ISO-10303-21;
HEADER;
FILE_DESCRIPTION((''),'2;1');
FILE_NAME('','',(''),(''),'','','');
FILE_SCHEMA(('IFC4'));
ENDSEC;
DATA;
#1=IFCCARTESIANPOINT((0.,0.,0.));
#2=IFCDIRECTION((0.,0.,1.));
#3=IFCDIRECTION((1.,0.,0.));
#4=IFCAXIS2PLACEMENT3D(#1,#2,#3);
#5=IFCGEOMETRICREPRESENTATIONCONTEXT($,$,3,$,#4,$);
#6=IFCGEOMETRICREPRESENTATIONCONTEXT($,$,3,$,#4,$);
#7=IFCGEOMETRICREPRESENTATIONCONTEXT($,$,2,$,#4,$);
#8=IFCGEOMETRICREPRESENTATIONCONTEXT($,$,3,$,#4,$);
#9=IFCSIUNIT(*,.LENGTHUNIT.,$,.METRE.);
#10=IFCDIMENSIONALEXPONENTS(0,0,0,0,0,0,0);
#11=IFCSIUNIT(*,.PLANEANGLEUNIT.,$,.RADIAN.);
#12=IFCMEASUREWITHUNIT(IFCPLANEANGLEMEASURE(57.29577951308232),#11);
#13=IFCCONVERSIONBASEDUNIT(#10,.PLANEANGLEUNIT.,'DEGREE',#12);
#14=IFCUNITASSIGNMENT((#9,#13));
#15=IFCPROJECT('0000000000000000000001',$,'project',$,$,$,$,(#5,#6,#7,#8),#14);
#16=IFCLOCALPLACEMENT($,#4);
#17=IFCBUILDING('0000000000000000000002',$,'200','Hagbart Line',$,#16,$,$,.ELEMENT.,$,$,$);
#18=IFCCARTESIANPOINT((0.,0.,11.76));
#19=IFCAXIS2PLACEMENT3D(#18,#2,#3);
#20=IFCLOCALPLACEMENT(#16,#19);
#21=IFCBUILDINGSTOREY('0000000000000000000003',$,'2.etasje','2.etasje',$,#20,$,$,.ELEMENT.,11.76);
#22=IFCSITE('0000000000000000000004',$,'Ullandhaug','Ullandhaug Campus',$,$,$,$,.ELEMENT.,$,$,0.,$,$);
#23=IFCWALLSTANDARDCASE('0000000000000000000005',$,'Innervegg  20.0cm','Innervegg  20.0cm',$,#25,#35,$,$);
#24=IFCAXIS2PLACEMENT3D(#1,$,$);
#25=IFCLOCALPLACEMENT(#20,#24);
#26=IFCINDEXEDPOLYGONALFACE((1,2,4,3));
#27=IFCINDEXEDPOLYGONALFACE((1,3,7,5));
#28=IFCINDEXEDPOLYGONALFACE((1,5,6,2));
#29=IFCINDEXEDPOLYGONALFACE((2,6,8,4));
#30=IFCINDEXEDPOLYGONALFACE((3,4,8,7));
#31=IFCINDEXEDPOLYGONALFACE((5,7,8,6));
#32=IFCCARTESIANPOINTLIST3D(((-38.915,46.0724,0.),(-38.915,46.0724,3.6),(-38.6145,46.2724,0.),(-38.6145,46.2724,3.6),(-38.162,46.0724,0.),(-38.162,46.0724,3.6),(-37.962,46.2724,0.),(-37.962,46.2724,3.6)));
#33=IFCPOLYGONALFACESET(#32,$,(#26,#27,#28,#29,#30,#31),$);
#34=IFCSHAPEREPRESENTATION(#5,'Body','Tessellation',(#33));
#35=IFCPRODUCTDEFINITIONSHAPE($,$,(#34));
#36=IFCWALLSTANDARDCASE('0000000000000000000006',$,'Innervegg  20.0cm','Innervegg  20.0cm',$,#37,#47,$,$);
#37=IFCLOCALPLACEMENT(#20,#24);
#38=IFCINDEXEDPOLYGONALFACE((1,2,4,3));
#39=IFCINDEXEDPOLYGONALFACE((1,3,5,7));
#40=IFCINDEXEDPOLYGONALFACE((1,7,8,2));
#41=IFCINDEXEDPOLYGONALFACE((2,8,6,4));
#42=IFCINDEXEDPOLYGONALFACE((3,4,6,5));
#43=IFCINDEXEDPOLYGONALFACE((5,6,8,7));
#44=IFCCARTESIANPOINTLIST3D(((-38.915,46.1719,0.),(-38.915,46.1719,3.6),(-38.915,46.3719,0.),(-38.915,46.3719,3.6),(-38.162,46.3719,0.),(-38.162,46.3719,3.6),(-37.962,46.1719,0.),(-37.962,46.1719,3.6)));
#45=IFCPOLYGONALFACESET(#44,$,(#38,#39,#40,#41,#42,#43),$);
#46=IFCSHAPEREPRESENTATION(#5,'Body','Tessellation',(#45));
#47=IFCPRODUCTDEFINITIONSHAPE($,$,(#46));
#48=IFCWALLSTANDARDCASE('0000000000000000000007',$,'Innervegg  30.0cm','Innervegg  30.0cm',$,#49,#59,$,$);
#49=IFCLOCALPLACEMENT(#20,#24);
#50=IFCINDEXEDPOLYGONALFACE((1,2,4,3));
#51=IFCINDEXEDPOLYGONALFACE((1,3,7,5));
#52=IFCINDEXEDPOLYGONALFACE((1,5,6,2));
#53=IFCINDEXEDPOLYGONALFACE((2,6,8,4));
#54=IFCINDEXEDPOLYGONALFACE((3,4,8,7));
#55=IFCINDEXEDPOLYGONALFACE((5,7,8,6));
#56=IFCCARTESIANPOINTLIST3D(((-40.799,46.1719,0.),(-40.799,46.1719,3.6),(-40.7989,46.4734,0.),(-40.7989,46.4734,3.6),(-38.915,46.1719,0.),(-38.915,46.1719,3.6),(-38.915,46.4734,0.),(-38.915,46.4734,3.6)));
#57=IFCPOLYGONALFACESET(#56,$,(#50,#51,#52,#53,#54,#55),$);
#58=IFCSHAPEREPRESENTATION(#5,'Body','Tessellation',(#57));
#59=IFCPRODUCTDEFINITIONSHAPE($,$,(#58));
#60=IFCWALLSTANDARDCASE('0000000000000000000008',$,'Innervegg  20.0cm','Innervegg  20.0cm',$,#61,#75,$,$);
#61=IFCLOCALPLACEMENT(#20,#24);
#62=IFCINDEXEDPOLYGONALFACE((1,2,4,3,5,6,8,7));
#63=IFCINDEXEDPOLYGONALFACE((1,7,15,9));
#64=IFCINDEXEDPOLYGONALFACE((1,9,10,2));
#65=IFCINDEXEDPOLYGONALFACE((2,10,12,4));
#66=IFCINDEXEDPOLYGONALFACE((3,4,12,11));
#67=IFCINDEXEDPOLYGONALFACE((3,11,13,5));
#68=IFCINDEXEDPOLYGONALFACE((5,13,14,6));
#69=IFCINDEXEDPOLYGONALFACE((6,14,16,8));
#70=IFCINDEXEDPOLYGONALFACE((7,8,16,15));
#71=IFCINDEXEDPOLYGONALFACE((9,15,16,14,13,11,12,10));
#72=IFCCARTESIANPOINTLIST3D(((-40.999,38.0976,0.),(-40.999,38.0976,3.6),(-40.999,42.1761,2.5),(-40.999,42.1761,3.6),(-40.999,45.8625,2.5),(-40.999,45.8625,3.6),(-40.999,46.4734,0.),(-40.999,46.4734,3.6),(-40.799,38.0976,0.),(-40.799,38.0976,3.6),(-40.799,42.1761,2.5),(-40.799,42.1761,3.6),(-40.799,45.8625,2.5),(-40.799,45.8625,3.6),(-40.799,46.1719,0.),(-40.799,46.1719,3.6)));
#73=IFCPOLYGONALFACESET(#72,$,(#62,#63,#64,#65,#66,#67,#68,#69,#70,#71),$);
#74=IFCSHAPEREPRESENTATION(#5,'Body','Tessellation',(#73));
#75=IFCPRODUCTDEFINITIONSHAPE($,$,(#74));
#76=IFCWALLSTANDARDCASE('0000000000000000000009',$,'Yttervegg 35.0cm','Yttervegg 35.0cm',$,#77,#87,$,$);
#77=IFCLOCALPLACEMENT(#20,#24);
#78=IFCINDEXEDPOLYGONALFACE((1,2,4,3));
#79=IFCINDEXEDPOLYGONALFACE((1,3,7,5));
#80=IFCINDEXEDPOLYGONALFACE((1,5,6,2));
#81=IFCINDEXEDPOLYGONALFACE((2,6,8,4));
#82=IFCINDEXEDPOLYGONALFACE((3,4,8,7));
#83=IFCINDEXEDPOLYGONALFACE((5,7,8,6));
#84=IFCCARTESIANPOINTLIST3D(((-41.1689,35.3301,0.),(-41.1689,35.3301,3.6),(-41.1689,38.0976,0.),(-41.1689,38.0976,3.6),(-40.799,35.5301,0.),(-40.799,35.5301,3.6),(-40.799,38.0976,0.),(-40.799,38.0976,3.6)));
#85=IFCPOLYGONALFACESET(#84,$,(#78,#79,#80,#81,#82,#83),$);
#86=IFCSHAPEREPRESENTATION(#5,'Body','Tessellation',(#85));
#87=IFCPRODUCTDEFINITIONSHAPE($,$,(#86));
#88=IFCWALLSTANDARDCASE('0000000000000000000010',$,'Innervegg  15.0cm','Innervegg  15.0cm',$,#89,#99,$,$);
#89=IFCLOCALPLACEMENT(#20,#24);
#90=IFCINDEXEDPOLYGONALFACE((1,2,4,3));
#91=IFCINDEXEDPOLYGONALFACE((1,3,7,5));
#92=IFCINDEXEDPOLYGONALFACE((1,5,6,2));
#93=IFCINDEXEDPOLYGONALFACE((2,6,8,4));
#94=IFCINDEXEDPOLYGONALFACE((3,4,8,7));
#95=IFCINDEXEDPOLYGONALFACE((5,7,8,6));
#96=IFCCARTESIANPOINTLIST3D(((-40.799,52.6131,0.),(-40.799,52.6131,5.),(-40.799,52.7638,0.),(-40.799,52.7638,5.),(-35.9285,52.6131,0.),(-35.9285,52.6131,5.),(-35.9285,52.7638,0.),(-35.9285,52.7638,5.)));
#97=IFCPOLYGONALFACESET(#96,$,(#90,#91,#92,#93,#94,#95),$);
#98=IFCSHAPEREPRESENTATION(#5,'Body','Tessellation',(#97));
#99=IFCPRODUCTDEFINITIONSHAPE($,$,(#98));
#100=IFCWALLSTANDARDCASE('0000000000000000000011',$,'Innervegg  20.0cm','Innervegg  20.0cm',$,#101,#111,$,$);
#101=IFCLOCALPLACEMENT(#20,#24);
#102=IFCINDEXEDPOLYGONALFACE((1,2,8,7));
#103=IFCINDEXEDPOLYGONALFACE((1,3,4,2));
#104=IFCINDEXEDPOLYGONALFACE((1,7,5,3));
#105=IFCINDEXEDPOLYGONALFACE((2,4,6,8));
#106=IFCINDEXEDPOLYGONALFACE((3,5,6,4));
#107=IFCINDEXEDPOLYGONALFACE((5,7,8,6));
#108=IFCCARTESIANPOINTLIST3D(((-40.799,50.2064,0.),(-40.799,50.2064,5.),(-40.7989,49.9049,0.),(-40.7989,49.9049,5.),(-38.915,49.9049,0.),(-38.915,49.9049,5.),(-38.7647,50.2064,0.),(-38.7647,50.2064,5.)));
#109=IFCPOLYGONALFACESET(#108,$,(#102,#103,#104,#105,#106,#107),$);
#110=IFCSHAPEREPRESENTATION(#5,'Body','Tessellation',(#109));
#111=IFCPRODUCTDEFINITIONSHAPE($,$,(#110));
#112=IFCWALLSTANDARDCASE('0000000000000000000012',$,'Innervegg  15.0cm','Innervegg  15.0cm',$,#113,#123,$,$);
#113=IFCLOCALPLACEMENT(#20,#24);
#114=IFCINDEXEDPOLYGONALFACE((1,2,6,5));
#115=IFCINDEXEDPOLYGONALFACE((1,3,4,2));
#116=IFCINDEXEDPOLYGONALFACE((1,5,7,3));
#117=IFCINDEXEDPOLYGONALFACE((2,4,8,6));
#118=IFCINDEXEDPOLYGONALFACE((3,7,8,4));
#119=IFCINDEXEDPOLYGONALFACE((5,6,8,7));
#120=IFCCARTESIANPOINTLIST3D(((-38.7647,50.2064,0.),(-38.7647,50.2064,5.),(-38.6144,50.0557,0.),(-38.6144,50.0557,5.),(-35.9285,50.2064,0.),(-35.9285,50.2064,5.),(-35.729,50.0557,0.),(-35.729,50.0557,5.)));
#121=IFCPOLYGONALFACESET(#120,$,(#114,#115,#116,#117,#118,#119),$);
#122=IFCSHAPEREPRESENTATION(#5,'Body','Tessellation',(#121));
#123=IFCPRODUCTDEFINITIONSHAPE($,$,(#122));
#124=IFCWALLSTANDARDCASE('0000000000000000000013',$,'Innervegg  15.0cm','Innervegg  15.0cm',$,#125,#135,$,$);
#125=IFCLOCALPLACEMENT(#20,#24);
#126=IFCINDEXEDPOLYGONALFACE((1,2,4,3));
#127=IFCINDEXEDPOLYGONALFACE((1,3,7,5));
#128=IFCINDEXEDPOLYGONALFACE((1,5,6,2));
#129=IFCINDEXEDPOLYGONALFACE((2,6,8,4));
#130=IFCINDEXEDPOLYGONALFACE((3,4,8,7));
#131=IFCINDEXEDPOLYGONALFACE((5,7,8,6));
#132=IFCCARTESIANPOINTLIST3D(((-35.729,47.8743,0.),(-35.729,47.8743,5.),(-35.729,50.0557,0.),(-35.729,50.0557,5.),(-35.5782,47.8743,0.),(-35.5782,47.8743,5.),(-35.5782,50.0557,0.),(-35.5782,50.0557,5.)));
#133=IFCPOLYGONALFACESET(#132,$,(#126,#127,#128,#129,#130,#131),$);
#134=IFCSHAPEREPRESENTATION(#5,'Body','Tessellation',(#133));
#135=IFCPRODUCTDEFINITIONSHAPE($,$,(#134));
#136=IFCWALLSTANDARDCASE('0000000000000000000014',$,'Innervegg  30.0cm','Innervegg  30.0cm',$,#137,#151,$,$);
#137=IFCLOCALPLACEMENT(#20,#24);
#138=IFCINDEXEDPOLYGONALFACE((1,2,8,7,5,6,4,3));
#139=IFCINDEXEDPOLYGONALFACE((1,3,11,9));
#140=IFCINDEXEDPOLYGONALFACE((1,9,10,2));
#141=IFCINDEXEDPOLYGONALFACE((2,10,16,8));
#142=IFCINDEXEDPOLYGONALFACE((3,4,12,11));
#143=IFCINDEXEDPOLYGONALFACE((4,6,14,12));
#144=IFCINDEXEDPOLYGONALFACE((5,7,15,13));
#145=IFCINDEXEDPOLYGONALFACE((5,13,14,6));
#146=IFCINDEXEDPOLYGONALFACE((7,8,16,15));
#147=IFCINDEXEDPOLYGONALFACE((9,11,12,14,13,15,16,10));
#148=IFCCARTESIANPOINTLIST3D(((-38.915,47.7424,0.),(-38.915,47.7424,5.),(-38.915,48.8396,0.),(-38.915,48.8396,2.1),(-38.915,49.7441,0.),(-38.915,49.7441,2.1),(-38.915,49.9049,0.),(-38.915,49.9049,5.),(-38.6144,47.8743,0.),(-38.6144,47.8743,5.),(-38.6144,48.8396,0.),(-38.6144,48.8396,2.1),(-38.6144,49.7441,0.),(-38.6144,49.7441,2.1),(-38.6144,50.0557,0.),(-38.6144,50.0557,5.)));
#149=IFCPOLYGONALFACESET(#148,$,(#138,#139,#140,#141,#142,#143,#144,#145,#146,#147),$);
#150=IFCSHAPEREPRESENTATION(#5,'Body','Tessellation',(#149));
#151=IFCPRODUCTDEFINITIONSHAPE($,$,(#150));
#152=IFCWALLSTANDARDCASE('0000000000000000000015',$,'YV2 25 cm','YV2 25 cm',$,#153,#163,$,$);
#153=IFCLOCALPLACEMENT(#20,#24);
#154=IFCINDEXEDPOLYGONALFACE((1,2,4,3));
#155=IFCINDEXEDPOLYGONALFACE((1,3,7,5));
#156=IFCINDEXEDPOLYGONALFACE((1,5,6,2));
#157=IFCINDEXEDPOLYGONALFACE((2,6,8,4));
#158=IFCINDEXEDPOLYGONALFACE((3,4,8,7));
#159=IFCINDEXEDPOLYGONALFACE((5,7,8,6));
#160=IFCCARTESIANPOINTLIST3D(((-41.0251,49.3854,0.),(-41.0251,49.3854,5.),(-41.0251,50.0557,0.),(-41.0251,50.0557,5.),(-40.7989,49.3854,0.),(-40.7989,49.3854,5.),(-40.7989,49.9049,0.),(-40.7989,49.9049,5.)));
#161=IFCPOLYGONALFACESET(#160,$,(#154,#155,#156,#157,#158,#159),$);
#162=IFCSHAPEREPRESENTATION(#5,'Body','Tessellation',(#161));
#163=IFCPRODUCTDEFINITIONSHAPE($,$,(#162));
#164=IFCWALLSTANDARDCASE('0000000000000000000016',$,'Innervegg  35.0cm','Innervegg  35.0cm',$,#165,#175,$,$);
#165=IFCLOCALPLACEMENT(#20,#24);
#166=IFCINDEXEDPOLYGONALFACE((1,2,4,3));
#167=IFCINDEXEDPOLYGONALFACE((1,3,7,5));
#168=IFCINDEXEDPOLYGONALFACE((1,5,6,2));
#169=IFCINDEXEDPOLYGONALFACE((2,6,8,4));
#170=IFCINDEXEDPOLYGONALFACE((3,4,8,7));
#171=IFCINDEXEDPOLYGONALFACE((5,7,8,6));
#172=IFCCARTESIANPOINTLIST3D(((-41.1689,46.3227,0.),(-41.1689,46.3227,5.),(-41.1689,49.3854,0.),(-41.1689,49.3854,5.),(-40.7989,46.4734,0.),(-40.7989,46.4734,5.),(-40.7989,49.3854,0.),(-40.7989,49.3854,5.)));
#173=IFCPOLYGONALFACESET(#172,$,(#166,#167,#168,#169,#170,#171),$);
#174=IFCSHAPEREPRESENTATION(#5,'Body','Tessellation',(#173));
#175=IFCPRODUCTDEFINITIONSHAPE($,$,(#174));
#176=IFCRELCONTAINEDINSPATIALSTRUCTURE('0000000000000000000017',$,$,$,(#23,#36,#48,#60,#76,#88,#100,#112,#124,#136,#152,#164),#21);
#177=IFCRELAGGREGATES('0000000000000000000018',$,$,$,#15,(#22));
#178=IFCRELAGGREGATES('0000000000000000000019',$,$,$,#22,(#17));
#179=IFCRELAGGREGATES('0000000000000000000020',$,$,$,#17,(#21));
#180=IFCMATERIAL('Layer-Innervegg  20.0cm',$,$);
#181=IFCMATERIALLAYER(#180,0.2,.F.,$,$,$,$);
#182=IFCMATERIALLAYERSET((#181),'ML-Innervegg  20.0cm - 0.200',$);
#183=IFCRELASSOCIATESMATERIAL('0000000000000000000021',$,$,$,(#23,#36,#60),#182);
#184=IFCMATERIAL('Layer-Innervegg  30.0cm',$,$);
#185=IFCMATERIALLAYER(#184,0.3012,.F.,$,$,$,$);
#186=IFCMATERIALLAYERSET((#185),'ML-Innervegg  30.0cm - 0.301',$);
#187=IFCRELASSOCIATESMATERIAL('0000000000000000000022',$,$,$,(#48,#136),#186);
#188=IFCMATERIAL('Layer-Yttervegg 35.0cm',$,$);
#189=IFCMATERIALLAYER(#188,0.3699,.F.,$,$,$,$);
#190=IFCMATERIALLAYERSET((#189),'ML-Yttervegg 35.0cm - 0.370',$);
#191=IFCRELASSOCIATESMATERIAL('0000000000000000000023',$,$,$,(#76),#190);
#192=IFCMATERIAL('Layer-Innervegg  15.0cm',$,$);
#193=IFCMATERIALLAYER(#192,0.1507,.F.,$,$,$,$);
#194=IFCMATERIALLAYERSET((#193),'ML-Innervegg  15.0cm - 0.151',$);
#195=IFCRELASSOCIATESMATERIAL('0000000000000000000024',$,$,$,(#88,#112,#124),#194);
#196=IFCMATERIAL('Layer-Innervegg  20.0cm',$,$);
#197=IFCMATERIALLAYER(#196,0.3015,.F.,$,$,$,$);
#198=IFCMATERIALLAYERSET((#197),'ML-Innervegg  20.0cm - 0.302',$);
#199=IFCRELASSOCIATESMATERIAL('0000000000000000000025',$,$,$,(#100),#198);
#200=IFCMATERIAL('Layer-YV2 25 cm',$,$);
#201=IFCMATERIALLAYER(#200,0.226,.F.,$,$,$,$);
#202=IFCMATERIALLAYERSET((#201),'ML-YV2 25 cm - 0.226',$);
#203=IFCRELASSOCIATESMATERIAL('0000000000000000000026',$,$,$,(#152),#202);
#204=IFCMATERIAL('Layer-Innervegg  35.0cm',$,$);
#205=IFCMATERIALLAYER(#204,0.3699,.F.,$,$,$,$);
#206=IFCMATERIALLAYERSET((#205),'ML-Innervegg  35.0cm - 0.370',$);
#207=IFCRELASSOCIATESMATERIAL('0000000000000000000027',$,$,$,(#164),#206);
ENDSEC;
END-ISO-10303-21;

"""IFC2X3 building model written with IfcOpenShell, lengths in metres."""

from ifc_helpers import new_model, entity, si_unit, converted_unit, frame, origin_with_axes, place, context, project, spatial, polyline, outline, extrude, material, layer, layer_set, layer_usage, element, save


model = new_model("IFC2X3")

# Units and contexts
context_of_model_1 = context(None, 3, world=origin_with_axes())
context_of_model_2 = context(None, 3, world=origin_with_axes())
context_of_model_3 = context(None, 2, world=origin_with_axes())
context_of_model_4 = context(None, 3, world=origin_with_axes())
ifc_project = project(units=[si_unit("LENGTHUNIT", "METRE"), converted_unit("PLANEANGLEUNIT", "DEGREE", entity("IfcPlaneAngleMeasure", 57.29577951308232), si_unit("PLANEANGLEUNIT", "RADIAN"), dimensions=[0, 0, 0, 0, 0, 0, 0])], contexts=[context_of_model_1, context_of_model_2, context_of_model_3, context_of_model_4])

# Site, building, storey
site = spatial("IfcSite", under=ifc_project, Name="Ullandhaug", Description="Ullandhaug Campus", CompositionType="ELEMENT", RefElevation=0.0)
building_placement = place(None, origin_with_axes())
building = spatial("IfcBuilding", under=site, at=building_placement, Name="200", Description="Hagbart Line", CompositionType="ELEMENT")
storey_placement = place(building_placement, frame((0.0, 0.0, 11.76), z_axis=(0.0, 0.0, 1.0), x_axis=(1.0, 0.0, 0.0)))
storey = spatial("IfcBuildingStorey", under=building, at=storey_placement, Name="2.etasje", Description="2.etasje", CompositionType="ELEMENT", Elevation=11.76)

# Walls
ifc_material_1 = material(Name="Layer-Innervegg  35.0cm")
ifc_layer_1 = layer(ifc_material_1, 0.3699, ventilated=False)
ifc_layer_set_1 = layer_set([ifc_layer_1], Name="ML-Innervegg  35.0cm - 0.370")
ifc_layer_usage_1 = layer_usage(ifc_layer_set_1, "AXIS2", "POSITIVE", 0.0)
ifc_material_2 = material(Name="Layer-Innervegg  20.0cm")
ifc_layer_2 = layer(ifc_material_2, 0.2, ventilated=False)
ifc_layer_set_2 = layer_set([ifc_layer_2], Name="ML-Innervegg  20.0cm - 0.200")
ifc_layer_usage_2 = layer_usage(ifc_layer_set_2, "AXIS2", "POSITIVE", 0.0)
wall_1_placement = place(storey_placement, frame((-38.915, 46.0724, 0.0), z_axis=(0.0, 0.0, 1.0), x_axis=(1.0, 0.0, 0.0)))
element("IfcWallStandardCase", 1, at=wall_1_placement, inside=storey, material=ifc_layer_usage_2, Name="Innervegg  20.0cm", Description="Innervegg  20.0cm", context=context_of_model_1, shape_type="SweptSolid", body=[
    extrude(outline(polyline([(0.0, 0.0), (0.753, 0.0), (0.953, 0.2), (0.3005, 0.2), (0.0, 0.0)])), origin_with_axes(), (0.0, 0.0, 1.0), 3.6),
])
wall_2_placement = place(storey_placement, frame((-38.162, 46.3719, 0.0), z_axis=(0.0, 0.0, 1.0), x_axis=(-1.0, 0.0, 0.0)))
element("IfcWallStandardCase", 2, at=wall_2_placement, inside=storey, material=ifc_layer_usage_2, Name="Innervegg  20.0cm", Description="Innervegg  20.0cm", context=context_of_model_1, shape_type="SweptSolid", body=[
    extrude(outline(polyline([(0.0, 0.0), (0.753, 0.0), (0.753, 0.2), (-0.2, 0.2), (0.0, 0.0)])), frame((0.0, 0.0, 0.0), z_axis=(0.0, 0.0, 1.0), x_axis=(1.0, 0.0, 0.0)), (0.0, 0.0, 1.0), 3.6),
])
ifc_material_3 = material(Name="Layer-Innervegg  30.0cm")
ifc_layer_3 = layer(ifc_material_3, 0.3012, ventilated=False)
ifc_layer_set_3 = layer_set([ifc_layer_3], Name="ML-Innervegg  30.0cm - 0.301")
ifc_layer_usage_3 = layer_usage(ifc_layer_set_3, "AXIS2", "POSITIVE", 0.0)
wall_3_placement = place(storey_placement, frame((-38.915, 46.4734, 0.0), z_axis=(0.0, 0.0, 1.0), x_axis=(-1.0, 0.0, 0.0)))
element("IfcWallStandardCase", 3, at=wall_3_placement, inside=storey, material=ifc_layer_usage_3, Name="Innervegg  30.0cm", Description="Innervegg  30.0cm", context=context_of_model_1, shape_type="SweptSolid", body=[
    extrude(outline(polyline([(0.0, 0.0), (1.8839, 0.0), (1.884, 0.3015), (0.0, 0.3015), (0.0, 0.0)])), frame((0.0, 0.0, 0.0), z_axis=(0.0, 0.0, 1.0), x_axis=(1.0, 0.0, 0.0)), (0.0, 0.0, 1.0), 3.6),
])

# Wall, opening
wall_4_placement = place(storey_placement, frame((-40.999, 46.4734, 0.0), z_axis=(0.0, 0.0, 1.0), x_axis=(0.0, -1.0, 0.0)))
wall_4 = element("IfcWallStandardCase", 4, at=wall_4_placement, inside=storey, material=ifc_layer_usage_2, Name="Innervegg  20.0cm", Description="Innervegg  20.0cm", context=context_of_model_1, shape_type="SweptSolid", body=[
    extrude(outline(polyline([(0.0, 0.0), (8.3758, 0.0), (8.3758, 0.2), (0.3015, 0.2), (0.0, 0.0)])), frame((0.0, 0.0, 0.0), z_axis=(0.0, 0.0, 1.0), x_axis=(1.0, 0.0, 0.0)), (0.0, 0.0, 1.0), 3.6),
])
opening_1_placement = place(wall_4_placement, frame((0.611, 0.2, 2.5), z_axis=(0.0, 0.0, 1.0), x_axis=(1.0, 0.0, 0.0)))
element("IfcOpeningElement", 5, at=opening_1_placement, cuts=wall_4, context=context_of_model_1, shape_type="SweptSolid", body=[
    extrude(outline(polyline([(0.0, 0.0), (2.0, 0.0), (2.0, 3.6863), (0.0, 3.6863), (0.0, 0.0)])), frame((0.0, 0.0, 0.0), z_axis=(0.0, 1.0, 0.0), x_axis=(0.0, 0.0, 1.0)), (0.0, 0.0, -1.0), 0.2),
])

# Walls
ifc_material_4 = material(Name="Layer-Yttervegg 35.0cm")
ifc_layer_4 = layer(ifc_material_4, 0.3699, ventilated=False)
ifc_layer_set_4 = layer_set([ifc_layer_4], Name="ML-Yttervegg 35.0cm - 0.370")
ifc_layer_usage_4 = layer_usage(ifc_layer_set_4, "AXIS2", "POSITIVE", 0.0)
wall_5_placement = place(storey_placement, frame((-41.1689, 38.0976, 0.0), z_axis=(0.0, 0.0, 1.0), x_axis=(0.0, -1.0, 0.0)))
element("IfcWallStandardCase", 6, at=wall_5_placement, inside=storey, material=ifc_layer_usage_4, Name="Yttervegg 35.0cm", Description="Yttervegg 35.0cm", context=context_of_model_1, shape_type="SweptSolid", body=[
    extrude(outline(polyline([(0.0, 0.0), (2.7675, 0.0), (2.5675, 0.3699), (0.0, 0.3699), (0.0, 0.0)])), frame((0.0, 0.0, 0.0), z_axis=(0.0, 0.0, 1.0), x_axis=(1.0, 0.0, 0.0)), (0.0, 0.0, 1.0), 3.6),
])
ifc_material_5 = material(Name="Layer-Innervegg  15.0cm")
ifc_layer_5 = layer(ifc_material_5, 0.1507, ventilated=False)
ifc_layer_set_5 = layer_set([ifc_layer_5], Name="ML-Innervegg  15.0cm - 0.151")
ifc_layer_usage_5 = layer_usage(ifc_layer_set_5, "AXIS2", "POSITIVE", 0.0)
wall_6_placement = place(storey_placement, frame((-40.799, 52.6131, 0.0), z_axis=(0.0, 0.0, 1.0), x_axis=(1.0, 0.0, 0.0)))
element("IfcWallStandardCase", 7, at=wall_6_placement, inside=storey, material=ifc_layer_usage_5, Name="Innervegg  15.0cm", Description="Innervegg  15.0cm", context=context_of_model_1, shape_type="SweptSolid", body=[
    extrude(outline(polyline([(0.0, 0.0), (4.8704, 0.0), (4.8704, 0.1507), (0.0, 0.1507), (0.0, 0.0)])), origin_with_axes(), (0.0, 0.0, 1.0), 5.0),
])
ifc_material_6 = material(Name="Layer-Innervegg  20.0cm")
ifc_layer_6 = layer(ifc_material_6, 0.3015, ventilated=False)
ifc_layer_set_6 = layer_set([ifc_layer_6], Name="ML-Innervegg  20.0cm - 0.302")
ifc_layer_usage_6 = layer_usage(ifc_layer_set_6, "AXIS2", "POSITIVE", 0.0)
wall_7_placement = place(storey_placement, frame((-40.7989, 49.9049, 0.0), z_axis=(0.0, 0.0, 1.0), x_axis=(1.0, 0.0, 0.0)))
element("IfcWallStandardCase", 8, at=wall_7_placement, inside=storey, material=ifc_layer_usage_6, Name="Innervegg  20.0cm", Description="Innervegg  20.0cm", context=context_of_model_1, shape_type="SweptSolid", body=[
    extrude(outline(polyline([(0.0, 0.0), (1.8839, 0.0), (2.0342, 0.3015), (-0.0001, 0.3015), (0.0, 0.0)])), origin_with_axes(), (0.0, 0.0, 1.0), 5.0),
])
wall_8_placement = place(storey_placement, frame((-38.6144, 50.0557, 0.0), z_axis=(0.0, 0.0, 1.0), x_axis=(1.0, 0.0, 0.0)))
element("IfcWallStandardCase", 9, at=wall_8_placement, inside=storey, material=ifc_layer_usage_5, Name="Innervegg  15.0cm", Description="Innervegg  15.0cm", context=context_of_model_1, shape_type="SweptSolid", body=[
    extrude(outline(polyline([(0.0, 0.0), (2.8854, 0.0), (2.6859, 0.1508), (-0.1503, 0.1508), (0.0, 0.0)])), origin_with_axes(), (0.0, 0.0, 1.0), 5.0),
])
wall_9_placement = place(storey_placement, frame((-35.729, 50.0557, 0.0), z_axis=(0.0, 0.0, 1.0), x_axis=(0.0, -1.0, 0.0)))
element("IfcWallStandardCase", 10, at=wall_9_placement, inside=storey, material=ifc_layer_usage_5, Name="Innervegg  15.0cm", Description="Innervegg  15.0cm", context=context_of_model_1, shape_type="SweptSolid", body=[
    extrude(outline(polyline([(0.0, 0.0), (2.1814, 0.0), (2.1814, 0.1508), (0.0, 0.1508), (0.0, 0.0)])), frame((0.0, 0.0, 0.0), z_axis=(0.0, 0.0, 1.0), x_axis=(1.0, 0.0, 0.0)), (0.0, 0.0, 1.0), 5.0),
])

# Wall, opening
wall_10_placement = place(storey_placement, frame((-38.915, 49.9049, 0.0), z_axis=(0.0, 0.0, 1.0), x_axis=(0.0, -1.0, 0.0)))
wall_10 = element("IfcWallStandardCase", 11, at=wall_10_placement, inside=storey, material=ifc_layer_usage_3, Name="Innervegg  30.0cm", Description="Innervegg  30.0cm", context=context_of_model_1, shape_type="SweptSolid", body=[
    extrude(outline(polyline([(0.0, 0.0), (2.1625, 0.0), (2.0306, 0.3005), (-0.1507, 0.3005), (0.0, 0.0)])), frame((0.0, 0.0, 0.0), z_axis=(0.0, 0.0, 1.0), x_axis=(1.0, 0.0, 0.0)), (0.0, 0.0, 1.0), 5.0),
])
opening_2_placement = place(wall_10_placement, frame((0.1608, 0.3005, 0.0), z_axis=(0.0, 0.0, 1.0), x_axis=(1.0, 0.0, 0.0)))
element("IfcOpeningElement", 12, at=opening_2_placement, cuts=wall_10, context=context_of_model_1, shape_type="SweptSolid", body=[
    extrude(outline(polyline([(0.0, 0.0), (2.1, 0.0), (2.1, 0.9045), (0.0, 0.9045), (0.0, 0.0)])), frame((0.0, 0.0, 0.0), z_axis=(0.0, 1.0, 0.0), x_axis=(0.0, 0.0, 1.0)), (0.0, 0.0, -1.0), 0.3005),
])

# Walls
ifc_material_7 = material(Name="Layer-YV2 25 cm")
ifc_layer_7 = layer(ifc_material_7, 0.226, ventilated=False)
ifc_layer_set_7 = layer_set([ifc_layer_7], Name="ML-YV2 25 cm - 0.226")
ifc_layer_usage_7 = layer_usage(ifc_layer_set_7, "AXIS2", "POSITIVE", 0.0)
wall_11_placement = place(storey_placement, frame((-41.0251, 50.0557, 0.0), z_axis=(0.0, 0.0, 1.0), x_axis=(0.0, -1.0, 0.0)))
element("IfcWallStandardCase", 13, at=wall_11_placement, inside=storey, material=ifc_layer_usage_7, Name="YV2 25 cm", Description="YV2 25 cm", context=context_of_model_1, shape_type="SweptSolid", body=[
    extrude(outline(polyline([(0.0, 0.0), (0.6702, 0.0), (0.6702, 0.2262), (0.1508, 0.2262), (0.0, 0.0)])), frame((0.0, 0.0, 0.0), z_axis=(0.0, 0.0, 1.0), x_axis=(1.0, 0.0, 0.0)), (0.0, 0.0, 1.0), 5.0),
])
wall_12_placement = place(storey_placement, frame((-41.1689, 49.3854, 0.0), z_axis=(0.0, 0.0, 1.0), x_axis=(0.0, -1.0, 0.0)))
element("IfcWallStandardCase", 14, at=wall_12_placement, inside=storey, material=ifc_layer_usage_1, Name="Innervegg  35.0cm", Description="Innervegg  35.0cm", context=context_of_model_1, shape_type="SweptSolid", body=[
    extrude(outline(polyline([(0.0, 0.0), (3.0628, 0.0), (2.912, 0.37), (0.0, 0.37), (0.0, 0.0)])), frame((0.0, 0.0, 0.0), z_axis=(0.0, 0.0, 1.0), x_axis=(1.0, 0.0, 0.0)), (0.0, 0.0, 1.0), 5.0),
])

save(model, "model.ifc")
